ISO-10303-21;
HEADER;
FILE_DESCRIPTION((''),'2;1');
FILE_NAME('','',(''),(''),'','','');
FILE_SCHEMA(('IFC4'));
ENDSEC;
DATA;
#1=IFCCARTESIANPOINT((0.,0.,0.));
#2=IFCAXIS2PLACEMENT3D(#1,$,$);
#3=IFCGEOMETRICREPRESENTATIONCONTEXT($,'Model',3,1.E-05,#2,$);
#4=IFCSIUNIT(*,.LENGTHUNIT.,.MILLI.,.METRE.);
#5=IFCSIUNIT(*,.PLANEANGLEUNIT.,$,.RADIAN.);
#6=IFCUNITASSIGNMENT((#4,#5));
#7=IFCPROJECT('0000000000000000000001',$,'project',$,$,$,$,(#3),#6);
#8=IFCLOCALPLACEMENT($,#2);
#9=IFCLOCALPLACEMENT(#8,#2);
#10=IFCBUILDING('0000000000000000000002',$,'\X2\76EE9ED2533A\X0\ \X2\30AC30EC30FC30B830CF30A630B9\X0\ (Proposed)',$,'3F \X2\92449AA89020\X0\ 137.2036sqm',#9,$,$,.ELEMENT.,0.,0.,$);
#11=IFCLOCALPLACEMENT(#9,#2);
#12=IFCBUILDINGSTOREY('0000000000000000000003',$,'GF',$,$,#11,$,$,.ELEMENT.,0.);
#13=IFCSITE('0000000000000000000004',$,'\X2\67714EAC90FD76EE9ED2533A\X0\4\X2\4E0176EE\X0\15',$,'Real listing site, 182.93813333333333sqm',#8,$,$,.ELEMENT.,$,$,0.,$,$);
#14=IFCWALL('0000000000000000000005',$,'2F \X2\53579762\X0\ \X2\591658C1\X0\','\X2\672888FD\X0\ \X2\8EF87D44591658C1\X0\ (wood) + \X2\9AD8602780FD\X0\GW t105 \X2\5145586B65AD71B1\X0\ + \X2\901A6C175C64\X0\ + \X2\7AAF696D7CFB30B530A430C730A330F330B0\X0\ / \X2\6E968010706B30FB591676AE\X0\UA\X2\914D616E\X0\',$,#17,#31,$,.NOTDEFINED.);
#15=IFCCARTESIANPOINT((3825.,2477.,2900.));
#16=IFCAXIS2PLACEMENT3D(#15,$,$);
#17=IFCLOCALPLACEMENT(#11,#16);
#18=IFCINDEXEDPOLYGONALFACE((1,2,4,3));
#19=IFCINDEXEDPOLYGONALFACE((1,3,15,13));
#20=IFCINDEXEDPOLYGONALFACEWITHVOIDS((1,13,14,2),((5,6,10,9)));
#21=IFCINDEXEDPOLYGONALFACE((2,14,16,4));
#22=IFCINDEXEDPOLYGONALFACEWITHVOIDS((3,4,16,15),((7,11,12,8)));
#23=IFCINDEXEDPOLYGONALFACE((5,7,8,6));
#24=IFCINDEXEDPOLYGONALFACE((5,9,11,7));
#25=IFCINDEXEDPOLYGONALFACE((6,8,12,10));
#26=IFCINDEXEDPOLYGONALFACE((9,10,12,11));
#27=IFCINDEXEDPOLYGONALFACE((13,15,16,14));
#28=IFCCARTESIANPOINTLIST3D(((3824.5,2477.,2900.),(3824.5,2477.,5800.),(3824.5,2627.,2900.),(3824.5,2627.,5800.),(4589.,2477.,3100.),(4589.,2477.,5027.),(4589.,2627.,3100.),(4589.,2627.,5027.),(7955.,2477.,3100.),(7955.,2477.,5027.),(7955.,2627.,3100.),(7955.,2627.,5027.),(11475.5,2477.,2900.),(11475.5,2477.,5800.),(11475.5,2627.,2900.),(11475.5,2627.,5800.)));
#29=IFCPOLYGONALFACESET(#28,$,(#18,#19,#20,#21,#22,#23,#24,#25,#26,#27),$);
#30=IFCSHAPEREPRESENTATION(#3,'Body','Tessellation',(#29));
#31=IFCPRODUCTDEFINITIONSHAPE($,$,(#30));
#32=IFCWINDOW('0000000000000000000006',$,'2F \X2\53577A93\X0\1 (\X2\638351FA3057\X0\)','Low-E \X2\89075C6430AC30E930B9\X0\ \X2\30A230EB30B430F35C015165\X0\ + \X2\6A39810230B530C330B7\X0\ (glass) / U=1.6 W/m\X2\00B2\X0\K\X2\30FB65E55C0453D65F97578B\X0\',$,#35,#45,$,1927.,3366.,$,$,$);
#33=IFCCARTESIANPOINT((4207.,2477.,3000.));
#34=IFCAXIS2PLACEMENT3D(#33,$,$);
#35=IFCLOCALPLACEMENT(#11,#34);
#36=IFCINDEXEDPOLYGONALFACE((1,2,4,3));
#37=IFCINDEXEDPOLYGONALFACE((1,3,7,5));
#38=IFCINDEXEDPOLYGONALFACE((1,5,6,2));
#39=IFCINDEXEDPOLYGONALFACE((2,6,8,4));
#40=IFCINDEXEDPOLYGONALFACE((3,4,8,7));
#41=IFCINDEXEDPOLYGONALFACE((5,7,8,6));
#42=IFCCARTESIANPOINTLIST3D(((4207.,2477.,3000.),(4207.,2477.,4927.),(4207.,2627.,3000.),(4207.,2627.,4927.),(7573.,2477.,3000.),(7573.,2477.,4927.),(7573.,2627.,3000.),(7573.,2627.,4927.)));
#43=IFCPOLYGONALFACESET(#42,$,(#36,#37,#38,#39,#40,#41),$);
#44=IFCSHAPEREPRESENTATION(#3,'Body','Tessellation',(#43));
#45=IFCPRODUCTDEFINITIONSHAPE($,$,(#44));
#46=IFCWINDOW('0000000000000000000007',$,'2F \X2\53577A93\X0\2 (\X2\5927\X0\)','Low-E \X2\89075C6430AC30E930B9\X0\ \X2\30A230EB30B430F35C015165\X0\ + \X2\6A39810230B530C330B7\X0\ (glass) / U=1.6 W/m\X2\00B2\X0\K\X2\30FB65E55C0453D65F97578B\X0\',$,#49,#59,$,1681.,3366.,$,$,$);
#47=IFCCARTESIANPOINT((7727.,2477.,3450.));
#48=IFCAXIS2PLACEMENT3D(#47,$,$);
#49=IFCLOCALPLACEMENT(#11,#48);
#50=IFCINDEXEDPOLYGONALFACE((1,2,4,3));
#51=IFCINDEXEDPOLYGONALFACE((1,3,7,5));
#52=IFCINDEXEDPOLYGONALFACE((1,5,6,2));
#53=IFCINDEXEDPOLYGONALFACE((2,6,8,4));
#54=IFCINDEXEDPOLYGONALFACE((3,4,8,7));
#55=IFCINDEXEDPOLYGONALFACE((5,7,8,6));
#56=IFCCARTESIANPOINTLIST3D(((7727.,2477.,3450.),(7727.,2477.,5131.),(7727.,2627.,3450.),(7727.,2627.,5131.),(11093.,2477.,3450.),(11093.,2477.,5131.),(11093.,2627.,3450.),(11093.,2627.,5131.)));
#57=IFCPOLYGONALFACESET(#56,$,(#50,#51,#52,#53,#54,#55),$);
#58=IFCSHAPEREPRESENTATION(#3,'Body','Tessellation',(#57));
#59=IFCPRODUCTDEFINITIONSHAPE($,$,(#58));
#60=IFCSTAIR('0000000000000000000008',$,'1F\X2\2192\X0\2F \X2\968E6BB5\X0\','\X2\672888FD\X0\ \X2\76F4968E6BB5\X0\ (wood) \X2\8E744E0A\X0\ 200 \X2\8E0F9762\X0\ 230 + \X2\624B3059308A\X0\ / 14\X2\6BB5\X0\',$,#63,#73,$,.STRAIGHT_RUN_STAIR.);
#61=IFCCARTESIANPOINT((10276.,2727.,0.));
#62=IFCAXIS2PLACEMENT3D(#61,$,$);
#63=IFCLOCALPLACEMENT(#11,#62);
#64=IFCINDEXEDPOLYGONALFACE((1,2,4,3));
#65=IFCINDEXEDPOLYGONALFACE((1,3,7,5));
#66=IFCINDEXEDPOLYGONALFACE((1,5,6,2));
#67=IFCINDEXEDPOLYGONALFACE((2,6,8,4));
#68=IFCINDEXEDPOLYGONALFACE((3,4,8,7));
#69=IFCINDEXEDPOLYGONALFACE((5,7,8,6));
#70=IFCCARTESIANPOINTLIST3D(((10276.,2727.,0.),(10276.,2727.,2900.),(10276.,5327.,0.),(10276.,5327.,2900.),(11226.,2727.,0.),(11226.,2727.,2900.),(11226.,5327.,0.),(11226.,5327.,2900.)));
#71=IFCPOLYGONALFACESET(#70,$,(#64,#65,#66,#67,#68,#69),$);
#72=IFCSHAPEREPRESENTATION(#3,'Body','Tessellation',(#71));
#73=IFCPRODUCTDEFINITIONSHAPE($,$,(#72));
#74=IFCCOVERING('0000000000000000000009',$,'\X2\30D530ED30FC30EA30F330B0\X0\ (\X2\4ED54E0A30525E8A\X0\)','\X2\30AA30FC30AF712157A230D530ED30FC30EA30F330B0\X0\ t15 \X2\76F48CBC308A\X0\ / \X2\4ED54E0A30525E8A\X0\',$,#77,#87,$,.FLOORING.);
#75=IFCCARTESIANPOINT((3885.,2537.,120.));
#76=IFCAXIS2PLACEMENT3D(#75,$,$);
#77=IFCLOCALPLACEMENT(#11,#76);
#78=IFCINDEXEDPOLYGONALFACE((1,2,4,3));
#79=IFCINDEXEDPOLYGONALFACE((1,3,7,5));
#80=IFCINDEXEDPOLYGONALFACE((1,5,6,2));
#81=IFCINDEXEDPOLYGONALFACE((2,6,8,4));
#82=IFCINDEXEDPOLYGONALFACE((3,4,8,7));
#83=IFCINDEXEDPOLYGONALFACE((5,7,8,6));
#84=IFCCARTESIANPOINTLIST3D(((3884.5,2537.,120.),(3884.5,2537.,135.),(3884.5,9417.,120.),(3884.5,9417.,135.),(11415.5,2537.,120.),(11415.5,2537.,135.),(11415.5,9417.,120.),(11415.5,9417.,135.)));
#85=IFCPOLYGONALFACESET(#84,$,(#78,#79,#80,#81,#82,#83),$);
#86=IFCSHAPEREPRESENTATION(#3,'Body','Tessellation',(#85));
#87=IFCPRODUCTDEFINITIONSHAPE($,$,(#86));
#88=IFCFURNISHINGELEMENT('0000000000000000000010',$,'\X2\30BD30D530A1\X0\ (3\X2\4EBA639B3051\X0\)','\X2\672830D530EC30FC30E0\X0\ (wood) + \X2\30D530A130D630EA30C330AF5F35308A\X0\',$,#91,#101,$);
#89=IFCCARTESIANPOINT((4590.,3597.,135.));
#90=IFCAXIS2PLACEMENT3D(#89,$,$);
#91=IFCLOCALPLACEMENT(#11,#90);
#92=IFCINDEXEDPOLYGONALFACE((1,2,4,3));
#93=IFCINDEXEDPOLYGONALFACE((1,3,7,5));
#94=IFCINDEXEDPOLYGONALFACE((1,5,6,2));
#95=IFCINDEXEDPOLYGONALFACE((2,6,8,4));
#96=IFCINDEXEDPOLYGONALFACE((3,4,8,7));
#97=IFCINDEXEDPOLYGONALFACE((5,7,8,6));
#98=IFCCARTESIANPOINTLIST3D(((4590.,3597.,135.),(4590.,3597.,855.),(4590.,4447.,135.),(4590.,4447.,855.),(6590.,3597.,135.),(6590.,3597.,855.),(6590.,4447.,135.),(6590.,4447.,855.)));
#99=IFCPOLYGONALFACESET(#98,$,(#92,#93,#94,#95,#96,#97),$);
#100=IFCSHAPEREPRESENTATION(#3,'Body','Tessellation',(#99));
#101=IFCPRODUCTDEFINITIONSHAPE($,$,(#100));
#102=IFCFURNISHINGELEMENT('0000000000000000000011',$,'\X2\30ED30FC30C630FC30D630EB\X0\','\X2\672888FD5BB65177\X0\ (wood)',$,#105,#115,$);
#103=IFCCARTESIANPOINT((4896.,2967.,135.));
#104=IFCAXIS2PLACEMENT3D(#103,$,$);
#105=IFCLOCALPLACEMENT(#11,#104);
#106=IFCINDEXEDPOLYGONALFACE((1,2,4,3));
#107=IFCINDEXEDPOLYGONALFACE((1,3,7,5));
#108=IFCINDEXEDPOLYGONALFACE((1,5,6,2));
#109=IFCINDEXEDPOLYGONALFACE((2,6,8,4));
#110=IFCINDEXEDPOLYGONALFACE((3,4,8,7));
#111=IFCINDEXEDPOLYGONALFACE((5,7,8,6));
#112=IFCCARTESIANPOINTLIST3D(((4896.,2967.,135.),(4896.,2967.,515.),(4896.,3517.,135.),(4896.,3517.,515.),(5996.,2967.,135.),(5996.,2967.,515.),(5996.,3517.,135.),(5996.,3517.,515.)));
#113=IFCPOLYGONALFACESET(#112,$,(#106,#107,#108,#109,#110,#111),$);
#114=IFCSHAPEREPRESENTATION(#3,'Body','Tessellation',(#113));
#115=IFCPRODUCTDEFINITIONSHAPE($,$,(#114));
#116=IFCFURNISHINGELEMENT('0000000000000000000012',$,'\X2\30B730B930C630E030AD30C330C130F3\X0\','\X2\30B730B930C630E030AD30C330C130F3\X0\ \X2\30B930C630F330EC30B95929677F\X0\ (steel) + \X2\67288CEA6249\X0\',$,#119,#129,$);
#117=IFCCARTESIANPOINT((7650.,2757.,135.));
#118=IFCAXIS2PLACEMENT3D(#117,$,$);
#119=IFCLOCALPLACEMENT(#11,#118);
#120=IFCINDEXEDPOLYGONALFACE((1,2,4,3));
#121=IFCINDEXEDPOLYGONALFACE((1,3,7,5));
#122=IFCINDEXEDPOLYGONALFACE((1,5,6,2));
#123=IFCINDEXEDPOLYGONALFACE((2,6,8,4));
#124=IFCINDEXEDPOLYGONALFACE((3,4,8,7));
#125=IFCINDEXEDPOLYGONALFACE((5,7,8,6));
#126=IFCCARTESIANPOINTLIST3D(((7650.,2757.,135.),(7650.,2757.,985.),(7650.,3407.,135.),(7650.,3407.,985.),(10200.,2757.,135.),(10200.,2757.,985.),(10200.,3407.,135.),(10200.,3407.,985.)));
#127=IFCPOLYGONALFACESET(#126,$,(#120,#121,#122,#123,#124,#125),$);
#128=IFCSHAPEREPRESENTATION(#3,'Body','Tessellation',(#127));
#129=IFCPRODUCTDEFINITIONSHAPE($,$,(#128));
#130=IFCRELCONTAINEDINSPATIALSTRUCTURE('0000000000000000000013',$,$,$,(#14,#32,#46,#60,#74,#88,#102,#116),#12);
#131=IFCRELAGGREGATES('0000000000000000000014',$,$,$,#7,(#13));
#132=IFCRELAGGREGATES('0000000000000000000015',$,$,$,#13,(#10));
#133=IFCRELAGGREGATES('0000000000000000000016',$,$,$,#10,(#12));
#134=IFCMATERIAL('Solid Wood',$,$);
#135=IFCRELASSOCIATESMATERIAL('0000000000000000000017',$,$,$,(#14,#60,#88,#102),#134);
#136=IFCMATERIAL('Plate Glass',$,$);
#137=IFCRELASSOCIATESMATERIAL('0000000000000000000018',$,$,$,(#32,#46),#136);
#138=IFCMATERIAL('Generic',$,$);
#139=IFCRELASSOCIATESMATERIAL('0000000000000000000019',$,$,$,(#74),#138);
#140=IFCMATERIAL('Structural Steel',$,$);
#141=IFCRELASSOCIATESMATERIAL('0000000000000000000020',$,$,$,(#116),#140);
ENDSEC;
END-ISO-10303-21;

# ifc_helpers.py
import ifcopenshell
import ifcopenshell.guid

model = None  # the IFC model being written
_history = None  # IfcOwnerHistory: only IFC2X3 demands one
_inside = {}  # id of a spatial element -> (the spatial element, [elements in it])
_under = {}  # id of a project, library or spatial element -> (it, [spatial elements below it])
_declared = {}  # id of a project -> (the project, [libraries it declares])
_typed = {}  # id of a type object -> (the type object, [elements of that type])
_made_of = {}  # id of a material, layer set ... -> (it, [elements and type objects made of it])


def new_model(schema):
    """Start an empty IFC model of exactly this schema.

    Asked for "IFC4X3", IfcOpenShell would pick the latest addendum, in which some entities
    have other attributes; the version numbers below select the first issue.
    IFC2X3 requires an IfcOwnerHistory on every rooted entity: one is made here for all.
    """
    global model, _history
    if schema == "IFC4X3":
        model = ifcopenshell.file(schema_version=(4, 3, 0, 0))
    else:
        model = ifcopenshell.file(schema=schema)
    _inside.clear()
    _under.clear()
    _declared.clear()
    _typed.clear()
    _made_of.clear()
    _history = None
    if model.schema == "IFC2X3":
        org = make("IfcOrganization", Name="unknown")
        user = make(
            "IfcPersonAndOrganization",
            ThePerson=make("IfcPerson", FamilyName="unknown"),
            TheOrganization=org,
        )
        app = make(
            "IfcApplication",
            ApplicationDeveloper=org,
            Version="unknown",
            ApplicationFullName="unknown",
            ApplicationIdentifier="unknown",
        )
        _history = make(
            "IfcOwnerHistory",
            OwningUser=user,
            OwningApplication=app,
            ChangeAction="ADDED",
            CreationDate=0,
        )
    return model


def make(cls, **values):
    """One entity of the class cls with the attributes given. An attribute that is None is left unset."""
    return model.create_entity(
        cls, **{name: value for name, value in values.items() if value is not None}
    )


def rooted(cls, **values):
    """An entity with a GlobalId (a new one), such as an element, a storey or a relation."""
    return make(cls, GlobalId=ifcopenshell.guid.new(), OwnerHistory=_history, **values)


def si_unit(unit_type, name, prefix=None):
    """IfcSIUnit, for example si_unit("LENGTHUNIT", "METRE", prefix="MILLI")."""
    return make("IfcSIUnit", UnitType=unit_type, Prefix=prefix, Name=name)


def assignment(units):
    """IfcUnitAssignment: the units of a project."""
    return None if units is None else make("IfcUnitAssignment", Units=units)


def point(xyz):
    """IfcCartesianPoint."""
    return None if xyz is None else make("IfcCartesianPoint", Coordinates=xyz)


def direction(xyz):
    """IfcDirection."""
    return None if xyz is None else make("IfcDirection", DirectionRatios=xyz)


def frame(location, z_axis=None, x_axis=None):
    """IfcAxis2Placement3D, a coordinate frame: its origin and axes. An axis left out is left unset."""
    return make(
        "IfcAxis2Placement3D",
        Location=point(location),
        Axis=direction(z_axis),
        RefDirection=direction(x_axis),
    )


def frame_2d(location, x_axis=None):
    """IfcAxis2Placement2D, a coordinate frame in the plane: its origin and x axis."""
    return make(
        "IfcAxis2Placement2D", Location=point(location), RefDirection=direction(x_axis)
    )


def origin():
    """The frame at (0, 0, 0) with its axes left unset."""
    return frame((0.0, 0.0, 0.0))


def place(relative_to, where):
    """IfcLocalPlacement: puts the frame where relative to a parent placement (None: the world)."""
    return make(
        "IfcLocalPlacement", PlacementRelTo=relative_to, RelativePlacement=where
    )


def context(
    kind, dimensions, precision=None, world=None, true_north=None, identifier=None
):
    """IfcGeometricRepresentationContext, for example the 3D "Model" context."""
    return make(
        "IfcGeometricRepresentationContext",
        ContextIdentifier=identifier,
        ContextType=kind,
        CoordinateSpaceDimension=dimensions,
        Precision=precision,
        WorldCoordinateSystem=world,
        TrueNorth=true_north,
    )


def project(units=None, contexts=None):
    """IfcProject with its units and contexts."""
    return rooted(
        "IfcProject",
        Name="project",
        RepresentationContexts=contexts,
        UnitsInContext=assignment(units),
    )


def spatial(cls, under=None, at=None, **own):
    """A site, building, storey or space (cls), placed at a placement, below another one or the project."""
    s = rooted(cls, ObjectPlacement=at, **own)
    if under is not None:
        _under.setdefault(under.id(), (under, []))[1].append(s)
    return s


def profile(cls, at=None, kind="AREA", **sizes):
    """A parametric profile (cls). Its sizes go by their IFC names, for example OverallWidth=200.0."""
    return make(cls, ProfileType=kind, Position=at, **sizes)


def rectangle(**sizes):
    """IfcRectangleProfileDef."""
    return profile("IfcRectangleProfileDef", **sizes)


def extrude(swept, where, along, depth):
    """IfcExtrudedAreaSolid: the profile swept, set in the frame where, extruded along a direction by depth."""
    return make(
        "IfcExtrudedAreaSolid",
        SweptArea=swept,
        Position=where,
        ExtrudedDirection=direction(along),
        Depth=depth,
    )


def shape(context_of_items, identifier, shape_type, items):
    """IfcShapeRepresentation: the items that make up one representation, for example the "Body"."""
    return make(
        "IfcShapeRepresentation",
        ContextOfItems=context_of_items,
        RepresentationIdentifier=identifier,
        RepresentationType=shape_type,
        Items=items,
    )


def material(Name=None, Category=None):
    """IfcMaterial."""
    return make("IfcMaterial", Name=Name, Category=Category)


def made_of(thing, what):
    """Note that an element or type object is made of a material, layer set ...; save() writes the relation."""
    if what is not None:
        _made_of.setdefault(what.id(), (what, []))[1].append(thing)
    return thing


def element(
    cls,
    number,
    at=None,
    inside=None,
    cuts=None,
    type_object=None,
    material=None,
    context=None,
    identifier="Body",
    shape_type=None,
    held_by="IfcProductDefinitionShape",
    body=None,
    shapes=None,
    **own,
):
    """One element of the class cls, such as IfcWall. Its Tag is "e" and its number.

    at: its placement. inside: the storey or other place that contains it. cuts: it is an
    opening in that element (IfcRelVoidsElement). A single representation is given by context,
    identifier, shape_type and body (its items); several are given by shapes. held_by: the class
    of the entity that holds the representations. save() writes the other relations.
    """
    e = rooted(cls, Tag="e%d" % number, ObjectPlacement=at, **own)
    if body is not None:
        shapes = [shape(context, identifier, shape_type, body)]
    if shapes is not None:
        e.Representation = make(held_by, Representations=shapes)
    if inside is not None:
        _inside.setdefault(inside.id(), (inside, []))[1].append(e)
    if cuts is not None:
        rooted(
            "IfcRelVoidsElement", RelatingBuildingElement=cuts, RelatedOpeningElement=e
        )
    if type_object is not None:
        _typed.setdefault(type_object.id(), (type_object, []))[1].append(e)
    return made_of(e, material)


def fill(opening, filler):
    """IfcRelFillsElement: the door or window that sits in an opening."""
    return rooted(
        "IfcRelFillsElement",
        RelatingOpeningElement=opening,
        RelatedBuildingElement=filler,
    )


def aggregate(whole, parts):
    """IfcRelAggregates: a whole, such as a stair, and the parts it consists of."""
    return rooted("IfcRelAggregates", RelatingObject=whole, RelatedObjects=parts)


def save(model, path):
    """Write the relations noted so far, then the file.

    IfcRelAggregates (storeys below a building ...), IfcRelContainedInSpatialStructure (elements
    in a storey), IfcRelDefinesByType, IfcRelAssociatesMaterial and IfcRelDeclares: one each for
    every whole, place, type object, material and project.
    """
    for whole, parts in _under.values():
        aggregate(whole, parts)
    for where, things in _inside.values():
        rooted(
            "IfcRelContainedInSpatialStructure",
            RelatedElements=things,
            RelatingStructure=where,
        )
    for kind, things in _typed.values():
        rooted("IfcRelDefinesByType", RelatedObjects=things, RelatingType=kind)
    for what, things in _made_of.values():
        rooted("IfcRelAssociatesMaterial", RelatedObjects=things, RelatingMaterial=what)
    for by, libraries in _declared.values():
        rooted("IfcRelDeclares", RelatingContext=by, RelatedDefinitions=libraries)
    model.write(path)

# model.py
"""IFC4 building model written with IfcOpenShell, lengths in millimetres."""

from ifc_helpers import new_model, si_unit, frame, frame_2d, origin, place, context, project, spatial, rectangle, extrude, material, element, fill, save


model = new_model("IFC4")

# Units and contexts
model_context = context("Model", 3, precision=1e-05, world=origin())
ifc_project = project(units=[si_unit("LENGTHUNIT", "METRE", prefix="MILLI"), si_unit("PLANEANGLEUNIT", "RADIAN")], contexts=[model_context])

# Site, building, storey
site_placement = place(None, origin())
site = spatial("IfcSite", under=ifc_project, at=site_placement, Name="東京都目黒区4丁目15", ObjectType="Real listing site, 182.93813333333333sqm", CompositionType="ELEMENT", RefElevation=0.0)
building_placement = place(site_placement, origin())
building = spatial("IfcBuilding", under=site, at=building_placement, Name="目黒区 ガレージハウス (Proposed)", ObjectType="3F 鉄骨造 137.2036sqm", CompositionType="ELEMENT", ElevationOfRefHeight=0.0, ElevationOfTerrain=0.0)
storey_placement = place(building_placement, origin())
storey = spatial("IfcBuildingStorey", under=building, at=storey_placement, Name="GF", CompositionType="ELEMENT", Elevation=0.0)

# Shared definitions
ifc_material_1 = material(Name="Solid Wood")

# Shared definitions
ifc_material_2 = material(Name="Plate Glass")

# Wall, openings, windows
wall_1_placement = place(storey_placement, frame((3825.0, 2477.0, 2900.0)))
wall_1 = element("IfcWall", 1, at=wall_1_placement, inside=storey, material=ifc_material_1, Name="2F 南面 外壁", Description="木製 軸組外壁 (wood) + 高性能GW t105 充填断熱 + 通気層 + 窯業系サイディング / 準耐火・外皮UA配慮", PredefinedType="NOTDEFINED", context=model_context, shape_type="SweptSolid", body=[
    extrude(rectangle(XDim=7651.0, YDim=150.0, at=frame_2d((3825.0, 75.0))), frame((3825.0, 2477.0, 2900.0)), (0.0, 0.0, 1.0), 2900.0),
])
opening_1_placement = place(storey_placement, frame((4207.0, 2477.0, 3000.0)))
opening_1 = element("IfcOpeningElement", 2, at=opening_1_placement, cuts=wall_1, PredefinedType="NOTDEFINED", context=model_context, shape_type="SweptSolid", body=[
    extrude(rectangle(XDim=3366.0, YDim=150.0, at=frame_2d((1683.0, 75.0))), frame((4207.0, 2477.0, 3000.0)), (0.0, 0.0, 1.0), 1927.0),
])
opening_2_placement = place(storey_placement, frame((7727.0, 2477.0, 3450.0)))
opening_2 = element("IfcOpeningElement", 3, at=opening_2_placement, cuts=wall_1, PredefinedType="NOTDEFINED", context=model_context, shape_type="SweptSolid", body=[
    extrude(rectangle(XDim=3366.0, YDim=150.0, at=frame_2d((1683.0, 75.0))), frame((7727.0, 2477.0, 3450.0)), (0.0, 0.0, 1.0), 1681.0),
])
window_1_placement = place(storey_placement, frame((4207.0, 2477.0, 3000.0)))
window_1 = element("IfcWindow", 4, at=window_1_placement, inside=storey, material=ifc_material_2, Name="2F 南窓1 (掃出し)", Description="Low-E 複層ガラス アルゴン封入 + 樹脂サッシ (glass) / U=1.6 W/m²K・日射取得型", OverallHeight=1927.0, OverallWidth=3366.0, context=model_context, shape_type="SweptSolid", body=[
    extrude(rectangle(XDim=3366.0, YDim=150.0, at=frame_2d((1683.0, 75.0))), frame((4207.0, 2477.0, 3000.0)), (0.0, 0.0, 1.0), 1927.0),
])
fill(opening_1, window_1)
window_2_placement = place(storey_placement, frame((7727.0, 2477.0, 3450.0)))
window_2 = element("IfcWindow", 5, at=window_2_placement, inside=storey, material=ifc_material_2, Name="2F 南窓2 (大)", Description="Low-E 複層ガラス アルゴン封入 + 樹脂サッシ (glass) / U=1.6 W/m²K・日射取得型", OverallHeight=1681.0, OverallWidth=3366.0, context=model_context, shape_type="SweptSolid", body=[
    extrude(rectangle(XDim=3366.0, YDim=150.0, at=frame_2d((1683.0, 75.0))), frame((7727.0, 2477.0, 3450.0)), (0.0, 0.0, 1.0), 1681.0),
])
fill(opening_2, window_2)

# Stair
stair_placement = place(storey_placement, frame((10276.0, 2727.0, 0.0)))
element("IfcStair", 6, at=stair_placement, inside=storey, material=ifc_material_1, Name="1F→2F 階段", Description="木製 直階段 (wood) 蹴上 200 踏面 230 + 手すり / 14段", PredefinedType="STRAIGHT_RUN_STAIR", context=model_context, shape_type="SweptSolid", body=[
    extrude(rectangle(XDim=950.0, YDim=2600.0, at=frame_2d((475.0, 1300.0))), frame((10276.0, 2727.0, 0.0)), (0.0, 0.0, 1.0), 2900.0),
])

# Covering
ifc_material_3 = material(Name="Generic")
covering_placement = place(storey_placement, frame((3885.0, 2537.0, 120.0)))
element("IfcCovering", 7, at=covering_placement, inside=storey, material=ifc_material_3, Name="フローリング (仕上げ床)", Description="オーク無垢フローリング t15 直貼り / 仕上げ床", PredefinedType="FLOORING", context=model_context, shape_type="SweptSolid", body=[
    extrude(rectangle(XDim=7531.0, YDim=6880.0, at=frame_2d((3765.0, 3440.0))), frame((3885.0, 2537.0, 120.0)), (0.0, 0.0, 1.0), 15.0),
])

# Furnishing elements
furnishing_1_placement = place(storey_placement, frame((4590.0, 3597.0, 135.0)))
element("IfcFurnishingElement", 8, at=furnishing_1_placement, inside=storey, material=ifc_material_1, Name="ソファ (3人掛け)", Description="木フレーム (wood) + ファブリック張り", context=model_context, shape_type="SweptSolid", body=[
    extrude(rectangle(XDim=2000.0, YDim=850.0, at=frame_2d((1000.0, 425.0))), frame((4590.0, 3597.0, 135.0)), (0.0, 0.0, 1.0), 720.0),
])
furnishing_2_placement = place(storey_placement, frame((4896.0, 2967.0, 135.0)))
element("IfcFurnishingElement", 9, at=furnishing_2_placement, inside=storey, material=ifc_material_1, Name="ローテーブル", Description="木製家具 (wood)", context=model_context, shape_type="SweptSolid", body=[
    extrude(rectangle(XDim=1100.0, YDim=550.0, at=frame_2d((550.0, 275.0))), frame((4896.0, 2967.0, 135.0)), (0.0, 0.0, 1.0), 380.0),
])
ifc_material_4 = material(Name="Structural Steel")
furnishing_3_placement = place(storey_placement, frame((7650.0, 2757.0, 135.0)))
element("IfcFurnishingElement", 10, at=furnishing_3_placement, inside=storey, material=ifc_material_4, Name="システムキッチン", Description="システムキッチン ステンレス天板 (steel) + 木質扉", context=model_context, shape_type="SweptSolid", body=[
    extrude(rectangle(XDim=2550.0, YDim=650.0, at=frame_2d((1275.0, 325.0))), frame((7650.0, 2757.0, 135.0)), (0.0, 0.0, 1.0), 850.0),
])

save(model, "model.ifc")
